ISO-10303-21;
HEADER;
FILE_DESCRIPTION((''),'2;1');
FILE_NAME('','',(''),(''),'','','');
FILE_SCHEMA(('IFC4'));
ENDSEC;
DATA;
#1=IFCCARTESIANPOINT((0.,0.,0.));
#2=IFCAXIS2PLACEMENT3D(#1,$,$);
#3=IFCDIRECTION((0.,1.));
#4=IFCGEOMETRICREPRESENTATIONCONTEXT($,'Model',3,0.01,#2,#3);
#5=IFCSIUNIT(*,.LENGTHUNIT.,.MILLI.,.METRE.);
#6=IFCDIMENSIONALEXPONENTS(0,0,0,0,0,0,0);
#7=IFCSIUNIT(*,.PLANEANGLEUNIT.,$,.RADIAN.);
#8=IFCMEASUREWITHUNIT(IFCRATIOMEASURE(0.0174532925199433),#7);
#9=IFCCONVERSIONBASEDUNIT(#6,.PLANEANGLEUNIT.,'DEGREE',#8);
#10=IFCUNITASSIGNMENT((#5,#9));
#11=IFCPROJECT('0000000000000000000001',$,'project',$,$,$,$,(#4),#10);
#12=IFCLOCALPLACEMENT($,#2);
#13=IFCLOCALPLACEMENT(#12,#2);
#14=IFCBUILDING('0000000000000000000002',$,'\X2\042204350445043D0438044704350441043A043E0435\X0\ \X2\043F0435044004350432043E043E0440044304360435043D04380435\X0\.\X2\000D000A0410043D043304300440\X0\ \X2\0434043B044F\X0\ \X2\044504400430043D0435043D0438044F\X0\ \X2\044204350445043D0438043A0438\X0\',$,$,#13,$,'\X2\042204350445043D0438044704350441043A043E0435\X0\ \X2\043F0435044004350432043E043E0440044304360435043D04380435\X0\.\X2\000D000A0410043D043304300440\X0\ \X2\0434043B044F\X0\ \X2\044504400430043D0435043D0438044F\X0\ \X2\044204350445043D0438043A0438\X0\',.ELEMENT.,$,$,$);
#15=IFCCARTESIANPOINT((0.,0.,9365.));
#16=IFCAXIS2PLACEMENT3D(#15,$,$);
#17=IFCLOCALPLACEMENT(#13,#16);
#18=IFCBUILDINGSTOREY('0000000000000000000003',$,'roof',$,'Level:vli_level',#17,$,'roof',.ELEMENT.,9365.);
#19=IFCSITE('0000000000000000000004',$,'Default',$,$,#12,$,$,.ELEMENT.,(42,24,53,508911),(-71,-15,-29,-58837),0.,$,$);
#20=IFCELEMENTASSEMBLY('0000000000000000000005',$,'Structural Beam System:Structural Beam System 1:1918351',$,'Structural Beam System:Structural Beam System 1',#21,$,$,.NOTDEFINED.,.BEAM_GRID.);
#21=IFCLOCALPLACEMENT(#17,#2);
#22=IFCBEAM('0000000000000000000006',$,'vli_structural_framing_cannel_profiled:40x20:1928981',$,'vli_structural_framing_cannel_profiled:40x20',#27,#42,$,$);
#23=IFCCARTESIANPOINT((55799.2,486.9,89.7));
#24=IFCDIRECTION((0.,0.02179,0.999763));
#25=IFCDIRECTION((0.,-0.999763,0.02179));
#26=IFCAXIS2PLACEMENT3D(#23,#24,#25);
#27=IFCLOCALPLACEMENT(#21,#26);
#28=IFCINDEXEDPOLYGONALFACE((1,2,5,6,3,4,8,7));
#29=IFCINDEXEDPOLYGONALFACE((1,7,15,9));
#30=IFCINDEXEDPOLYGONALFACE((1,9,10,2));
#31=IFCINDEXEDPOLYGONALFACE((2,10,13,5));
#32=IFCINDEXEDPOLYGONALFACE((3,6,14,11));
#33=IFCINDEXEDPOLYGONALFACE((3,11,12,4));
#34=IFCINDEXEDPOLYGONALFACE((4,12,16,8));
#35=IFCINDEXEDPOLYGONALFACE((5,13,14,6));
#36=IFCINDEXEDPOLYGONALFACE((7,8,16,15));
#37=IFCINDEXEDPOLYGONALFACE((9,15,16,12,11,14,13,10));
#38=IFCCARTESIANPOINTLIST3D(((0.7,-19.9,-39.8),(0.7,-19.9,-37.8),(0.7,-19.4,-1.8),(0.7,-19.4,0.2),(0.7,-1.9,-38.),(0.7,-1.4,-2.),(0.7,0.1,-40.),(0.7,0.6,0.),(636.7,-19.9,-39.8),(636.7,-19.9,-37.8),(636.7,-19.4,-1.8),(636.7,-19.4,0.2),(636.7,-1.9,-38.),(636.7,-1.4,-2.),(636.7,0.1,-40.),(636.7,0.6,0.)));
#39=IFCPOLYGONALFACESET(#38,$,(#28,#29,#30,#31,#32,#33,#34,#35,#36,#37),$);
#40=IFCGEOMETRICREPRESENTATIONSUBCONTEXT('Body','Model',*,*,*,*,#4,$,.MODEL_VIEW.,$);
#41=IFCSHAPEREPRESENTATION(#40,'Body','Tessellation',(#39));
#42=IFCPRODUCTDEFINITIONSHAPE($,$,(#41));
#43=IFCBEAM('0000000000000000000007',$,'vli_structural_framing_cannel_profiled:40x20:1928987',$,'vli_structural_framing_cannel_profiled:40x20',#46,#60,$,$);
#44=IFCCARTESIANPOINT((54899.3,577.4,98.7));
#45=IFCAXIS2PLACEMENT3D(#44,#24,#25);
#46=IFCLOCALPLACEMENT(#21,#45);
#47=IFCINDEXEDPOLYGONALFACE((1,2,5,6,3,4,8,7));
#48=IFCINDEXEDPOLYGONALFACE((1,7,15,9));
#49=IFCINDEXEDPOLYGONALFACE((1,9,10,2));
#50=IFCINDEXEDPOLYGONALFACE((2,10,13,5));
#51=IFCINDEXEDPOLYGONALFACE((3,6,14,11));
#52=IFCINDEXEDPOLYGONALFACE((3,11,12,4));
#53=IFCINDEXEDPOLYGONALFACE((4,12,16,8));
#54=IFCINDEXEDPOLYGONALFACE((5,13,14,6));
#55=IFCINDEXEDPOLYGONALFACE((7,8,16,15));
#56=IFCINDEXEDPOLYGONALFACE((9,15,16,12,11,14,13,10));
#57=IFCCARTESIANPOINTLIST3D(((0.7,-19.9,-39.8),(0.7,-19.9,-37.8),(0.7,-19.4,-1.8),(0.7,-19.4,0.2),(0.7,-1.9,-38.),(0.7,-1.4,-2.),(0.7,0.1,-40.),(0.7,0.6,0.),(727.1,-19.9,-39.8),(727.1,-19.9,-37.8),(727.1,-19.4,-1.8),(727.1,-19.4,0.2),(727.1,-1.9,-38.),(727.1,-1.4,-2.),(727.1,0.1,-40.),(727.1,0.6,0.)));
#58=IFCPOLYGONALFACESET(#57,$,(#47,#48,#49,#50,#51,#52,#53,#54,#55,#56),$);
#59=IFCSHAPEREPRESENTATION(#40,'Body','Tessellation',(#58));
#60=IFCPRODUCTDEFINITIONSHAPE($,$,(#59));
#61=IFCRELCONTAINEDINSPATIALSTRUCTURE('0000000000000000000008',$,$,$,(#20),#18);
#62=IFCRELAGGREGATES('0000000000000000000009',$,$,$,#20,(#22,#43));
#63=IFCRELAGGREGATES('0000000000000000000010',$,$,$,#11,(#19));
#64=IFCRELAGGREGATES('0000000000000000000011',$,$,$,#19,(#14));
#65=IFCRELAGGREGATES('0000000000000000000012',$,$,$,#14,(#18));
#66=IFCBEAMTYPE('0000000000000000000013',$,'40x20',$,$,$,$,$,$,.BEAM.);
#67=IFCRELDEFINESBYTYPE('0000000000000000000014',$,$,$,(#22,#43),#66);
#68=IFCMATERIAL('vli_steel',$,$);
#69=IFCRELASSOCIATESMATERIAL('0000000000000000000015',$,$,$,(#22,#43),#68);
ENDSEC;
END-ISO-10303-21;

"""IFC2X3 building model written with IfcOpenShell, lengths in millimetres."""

from ifc_helpers import new_model, entity, si_unit, converted_unit, direction, frame, origin, place, context, subcontext, project, spatial, polyline, outline, extrude, material, type_object, element, aggregate, save


model = new_model("IFC2X3")

# Units and contexts
model_context = context("Model", 3, precision=0.01, world=origin(), true_north=direction((0.0, 1.0)))
body_context = subcontext(model_context, "Body", "Model", "MODEL_VIEW")
ifc_project = project(units=[si_unit("LENGTHUNIT", "METRE", prefix="MILLI"), converted_unit("PLANEANGLEUNIT", "DEGREE", entity("IfcRatioMeasure", 0.0174532925199433), si_unit("PLANEANGLEUNIT", "RADIAN"), dimensions=[0, 0, 0, 0, 0, 0, 0])], contexts=[model_context])

# Site, building, storey
site_placement = place(None, origin())
site = spatial("IfcSite", under=ifc_project, at=site_placement, Name="Default", CompositionType="ELEMENT", RefLatitude=(42, 24, 53, 508911), RefLongitude=(-71, -15, -29, -58837), RefElevation=0.0)
building_placement = place(site_placement, origin())
building = spatial("IfcBuilding", under=site, at=building_placement, Name="Техническое перевооружение.\r\nАнгар для хранения техники", LongName="Техническое перевооружение.\r\nАнгар для хранения техники", CompositionType="ELEMENT")
storey_placement = place(building_placement, frame((0.0, 0.0, 9365.0)))
storey = spatial("IfcBuildingStorey", under=building, at=storey_placement, Name="roof", ObjectType="Level:vli_level", LongName="roof", CompositionType="ELEMENT", Elevation=9365.0)

# Element assembly, beams
ifc_material = material(Name="vli_steel")
beam_type = type_object("IfcBeamType", Name="40x20", PredefinedType="BEAM")
assembly_1_placement = place(storey_placement, origin())
assembly_1 = element("IfcElementAssembly", 1, at=assembly_1_placement, inside=storey, Name="Structural Beam System:Structural Beam System 1:1918351", ObjectType="Structural Beam System:Structural Beam System 1", AssemblyPlace="NOTDEFINED", PredefinedType="BEAM_GRID")
beam_1_placement = place(assembly_1_placement, frame((55799.2, 486.9, 89.7), z_axis=(0.0, 0.02179, 0.999763), x_axis=(0.0, -0.999763, 0.02179)))
beam_1 = element("IfcBeam", 2, at=beam_1_placement, type_object=beam_type, material=ifc_material, Name="vli_structural_framing_cannel_profiled:40x20:1928981", ObjectType="vli_structural_framing_cannel_profiled:40x20", context=body_context, shape_type="SweptSolid", body=[
    extrude(outline(polyline([(-10.5, -20.0), (9.5, -20.0), (9.5, -18.0), (-8.5, -18.0), (-8.5, 18.0), (9.5, 18.0), (9.5, 20.0), (-10.5, 20.0), (-10.5, -20.0)])), frame((0.7, -10.1, -19.9), z_axis=(1.0, 0.0, 0.0), x_axis=(0.0, -0.999925, 0.012243)), (0.0, 0.0, 1.0), 636.0),
])
beam_2_placement = place(assembly_1_placement, frame((54899.3, 577.4, 98.7), z_axis=(0.0, 0.02179, 0.999763), x_axis=(0.0, -0.999763, 0.02179)))
beam_2 = element("IfcBeam", 3, at=beam_2_placement, type_object=beam_type, material=ifc_material, Name="vli_structural_framing_cannel_profiled:40x20:1928987", ObjectType="vli_structural_framing_cannel_profiled:40x20", context=body_context, shape_type="SweptSolid", body=[
    extrude(outline(polyline([(-10.5, -20.0), (9.5, -20.0), (9.5, -18.0), (-8.5, -18.0), (-8.5, 18.0), (9.5, 18.0), (9.5, 20.0), (-10.5, 20.0), (-10.5, -20.0)])), frame((0.7, -10.1, -19.9), z_axis=(1.0, 0.0, 0.0), x_axis=(0.0, -0.999925, 0.012243)), (0.0, 0.0, 1.0), 726.5),
])
aggregate(assembly_1, [beam_1, beam_2])

save(model, "model.ifc")
